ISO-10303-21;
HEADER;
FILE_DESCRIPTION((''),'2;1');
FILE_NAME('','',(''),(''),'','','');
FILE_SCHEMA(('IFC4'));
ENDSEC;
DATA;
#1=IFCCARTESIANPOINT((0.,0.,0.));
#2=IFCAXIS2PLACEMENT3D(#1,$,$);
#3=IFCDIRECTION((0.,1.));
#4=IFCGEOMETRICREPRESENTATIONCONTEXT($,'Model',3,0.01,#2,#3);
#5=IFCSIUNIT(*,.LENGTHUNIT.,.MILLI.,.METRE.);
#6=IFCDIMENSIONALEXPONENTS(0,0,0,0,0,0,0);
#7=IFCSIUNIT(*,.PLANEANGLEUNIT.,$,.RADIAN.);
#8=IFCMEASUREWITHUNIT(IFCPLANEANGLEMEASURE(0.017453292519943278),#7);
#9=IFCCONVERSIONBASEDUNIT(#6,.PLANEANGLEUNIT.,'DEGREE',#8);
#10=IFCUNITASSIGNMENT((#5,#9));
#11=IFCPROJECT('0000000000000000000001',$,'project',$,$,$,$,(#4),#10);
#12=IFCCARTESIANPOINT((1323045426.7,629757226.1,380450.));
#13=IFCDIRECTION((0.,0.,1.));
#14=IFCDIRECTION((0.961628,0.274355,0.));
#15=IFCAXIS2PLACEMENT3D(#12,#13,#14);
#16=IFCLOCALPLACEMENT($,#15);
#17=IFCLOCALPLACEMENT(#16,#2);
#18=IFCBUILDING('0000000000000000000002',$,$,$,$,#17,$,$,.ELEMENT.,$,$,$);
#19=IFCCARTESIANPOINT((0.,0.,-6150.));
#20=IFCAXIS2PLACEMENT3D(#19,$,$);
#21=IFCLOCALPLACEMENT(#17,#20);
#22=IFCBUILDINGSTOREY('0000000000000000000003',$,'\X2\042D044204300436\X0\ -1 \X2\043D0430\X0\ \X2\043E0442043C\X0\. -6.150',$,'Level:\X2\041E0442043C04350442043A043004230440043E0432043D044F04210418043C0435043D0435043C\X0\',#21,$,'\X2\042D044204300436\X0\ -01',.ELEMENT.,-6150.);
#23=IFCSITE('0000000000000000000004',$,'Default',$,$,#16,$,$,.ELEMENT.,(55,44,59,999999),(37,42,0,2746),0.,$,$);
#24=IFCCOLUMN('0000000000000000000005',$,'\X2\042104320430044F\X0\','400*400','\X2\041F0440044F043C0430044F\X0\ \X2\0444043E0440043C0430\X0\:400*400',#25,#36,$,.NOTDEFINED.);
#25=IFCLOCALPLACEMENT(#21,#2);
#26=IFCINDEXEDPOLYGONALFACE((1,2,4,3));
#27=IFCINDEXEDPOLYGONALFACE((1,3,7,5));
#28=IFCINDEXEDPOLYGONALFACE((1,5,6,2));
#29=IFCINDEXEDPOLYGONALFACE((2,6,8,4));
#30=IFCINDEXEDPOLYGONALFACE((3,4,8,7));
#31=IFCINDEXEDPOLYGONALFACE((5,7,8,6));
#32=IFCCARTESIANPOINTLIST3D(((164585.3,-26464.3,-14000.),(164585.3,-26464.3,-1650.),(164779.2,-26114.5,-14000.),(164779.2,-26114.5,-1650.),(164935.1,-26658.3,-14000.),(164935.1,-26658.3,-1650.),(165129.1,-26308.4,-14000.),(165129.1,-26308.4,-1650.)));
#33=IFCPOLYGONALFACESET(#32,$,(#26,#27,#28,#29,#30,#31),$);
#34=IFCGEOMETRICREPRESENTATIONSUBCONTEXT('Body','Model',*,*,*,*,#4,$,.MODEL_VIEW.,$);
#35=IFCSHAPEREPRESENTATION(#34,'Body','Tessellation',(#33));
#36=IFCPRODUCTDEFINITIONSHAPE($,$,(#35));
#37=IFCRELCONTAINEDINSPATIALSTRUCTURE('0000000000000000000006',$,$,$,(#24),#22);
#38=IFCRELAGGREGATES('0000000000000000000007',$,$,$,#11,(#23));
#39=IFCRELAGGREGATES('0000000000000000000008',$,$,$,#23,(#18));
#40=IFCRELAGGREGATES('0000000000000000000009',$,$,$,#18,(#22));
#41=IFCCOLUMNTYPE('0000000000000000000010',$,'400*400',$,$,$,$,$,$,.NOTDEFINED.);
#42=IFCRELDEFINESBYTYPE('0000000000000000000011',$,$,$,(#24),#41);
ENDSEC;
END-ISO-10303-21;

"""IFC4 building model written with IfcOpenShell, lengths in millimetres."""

from ifc_helpers import new_model, entity, si_unit, converted_unit, direction, frame, origin, place, context, subcontext, project, spatial, indexed_curve, outline, extrude, type_object, element, save


model = new_model("IFC4")

# Units and contexts
model_context = context("Model", 3, precision=0.01, world=origin(), true_north=direction((0.0, 1.0)))
body_context = subcontext(model_context, "Body", "Model", "MODEL_VIEW")
ifc_project = project(units=[si_unit("LENGTHUNIT", "METRE", prefix="MILLI"), converted_unit("PLANEANGLEUNIT", "DEGREE", entity("IfcPlaneAngleMeasure", 0.017453292519943278), si_unit("PLANEANGLEUNIT", "RADIAN"), dimensions=[0, 0, 0, 0, 0, 0, 0])], contexts=[model_context])

# Site, building, storey
site_placement = place(None, frame((1323045426.7, 629757226.1, 380450.0), z_axis=(0.0, 0.0, 1.0), x_axis=(0.961628, 0.274355, 0.0)))
site = spatial("IfcSite", under=ifc_project, at=site_placement, Name="Default", CompositionType="ELEMENT", RefLatitude=(55, 44, 59, 999999), RefLongitude=(37, 42, 0, 2746), RefElevation=0.0)
building_placement = place(site_placement, origin())
building = spatial("IfcBuilding", under=site, at=building_placement, CompositionType="ELEMENT")
storey_placement = place(building_placement, frame((0.0, 0.0, -6150.0)))
storey = spatial("IfcBuildingStorey", under=building, at=storey_placement, Name="Этаж -1 на отм. -6.150", ObjectType="Level:ОтметкаУровняСИменем", LongName="Этаж -01", CompositionType="ELEMENT", Elevation=-6150.0)

# Column
column_type = type_object("IfcColumnType", Name="400*400", PredefinedType="NOTDEFINED")
column_1_placement = place(storey_placement, origin())
element("IfcColumn", 1, at=column_1_placement, inside=storey, type_object=column_type, Name="Свая", Description="400*400", ObjectType="Прямая форма:400*400", PredefinedType="NOTDEFINED", context=body_context, shape_type="SweptSolid", body=[
    extrude(outline(indexed_curve([(-200.0, -200.0), (200.0, -200.0), (200.0, 200.0), (-200.0, 200.0), (-200.0, -200.0)], self_intersect=False)), frame((164857.2, -26386.4, -14000.0), z_axis=(0.0, 0.0, 1.0), x_axis=(0.48481, 0.87462, 0.0)), (0.0, 0.0, 1.0), 12350.0),
])

save(model, "model.ifc")
